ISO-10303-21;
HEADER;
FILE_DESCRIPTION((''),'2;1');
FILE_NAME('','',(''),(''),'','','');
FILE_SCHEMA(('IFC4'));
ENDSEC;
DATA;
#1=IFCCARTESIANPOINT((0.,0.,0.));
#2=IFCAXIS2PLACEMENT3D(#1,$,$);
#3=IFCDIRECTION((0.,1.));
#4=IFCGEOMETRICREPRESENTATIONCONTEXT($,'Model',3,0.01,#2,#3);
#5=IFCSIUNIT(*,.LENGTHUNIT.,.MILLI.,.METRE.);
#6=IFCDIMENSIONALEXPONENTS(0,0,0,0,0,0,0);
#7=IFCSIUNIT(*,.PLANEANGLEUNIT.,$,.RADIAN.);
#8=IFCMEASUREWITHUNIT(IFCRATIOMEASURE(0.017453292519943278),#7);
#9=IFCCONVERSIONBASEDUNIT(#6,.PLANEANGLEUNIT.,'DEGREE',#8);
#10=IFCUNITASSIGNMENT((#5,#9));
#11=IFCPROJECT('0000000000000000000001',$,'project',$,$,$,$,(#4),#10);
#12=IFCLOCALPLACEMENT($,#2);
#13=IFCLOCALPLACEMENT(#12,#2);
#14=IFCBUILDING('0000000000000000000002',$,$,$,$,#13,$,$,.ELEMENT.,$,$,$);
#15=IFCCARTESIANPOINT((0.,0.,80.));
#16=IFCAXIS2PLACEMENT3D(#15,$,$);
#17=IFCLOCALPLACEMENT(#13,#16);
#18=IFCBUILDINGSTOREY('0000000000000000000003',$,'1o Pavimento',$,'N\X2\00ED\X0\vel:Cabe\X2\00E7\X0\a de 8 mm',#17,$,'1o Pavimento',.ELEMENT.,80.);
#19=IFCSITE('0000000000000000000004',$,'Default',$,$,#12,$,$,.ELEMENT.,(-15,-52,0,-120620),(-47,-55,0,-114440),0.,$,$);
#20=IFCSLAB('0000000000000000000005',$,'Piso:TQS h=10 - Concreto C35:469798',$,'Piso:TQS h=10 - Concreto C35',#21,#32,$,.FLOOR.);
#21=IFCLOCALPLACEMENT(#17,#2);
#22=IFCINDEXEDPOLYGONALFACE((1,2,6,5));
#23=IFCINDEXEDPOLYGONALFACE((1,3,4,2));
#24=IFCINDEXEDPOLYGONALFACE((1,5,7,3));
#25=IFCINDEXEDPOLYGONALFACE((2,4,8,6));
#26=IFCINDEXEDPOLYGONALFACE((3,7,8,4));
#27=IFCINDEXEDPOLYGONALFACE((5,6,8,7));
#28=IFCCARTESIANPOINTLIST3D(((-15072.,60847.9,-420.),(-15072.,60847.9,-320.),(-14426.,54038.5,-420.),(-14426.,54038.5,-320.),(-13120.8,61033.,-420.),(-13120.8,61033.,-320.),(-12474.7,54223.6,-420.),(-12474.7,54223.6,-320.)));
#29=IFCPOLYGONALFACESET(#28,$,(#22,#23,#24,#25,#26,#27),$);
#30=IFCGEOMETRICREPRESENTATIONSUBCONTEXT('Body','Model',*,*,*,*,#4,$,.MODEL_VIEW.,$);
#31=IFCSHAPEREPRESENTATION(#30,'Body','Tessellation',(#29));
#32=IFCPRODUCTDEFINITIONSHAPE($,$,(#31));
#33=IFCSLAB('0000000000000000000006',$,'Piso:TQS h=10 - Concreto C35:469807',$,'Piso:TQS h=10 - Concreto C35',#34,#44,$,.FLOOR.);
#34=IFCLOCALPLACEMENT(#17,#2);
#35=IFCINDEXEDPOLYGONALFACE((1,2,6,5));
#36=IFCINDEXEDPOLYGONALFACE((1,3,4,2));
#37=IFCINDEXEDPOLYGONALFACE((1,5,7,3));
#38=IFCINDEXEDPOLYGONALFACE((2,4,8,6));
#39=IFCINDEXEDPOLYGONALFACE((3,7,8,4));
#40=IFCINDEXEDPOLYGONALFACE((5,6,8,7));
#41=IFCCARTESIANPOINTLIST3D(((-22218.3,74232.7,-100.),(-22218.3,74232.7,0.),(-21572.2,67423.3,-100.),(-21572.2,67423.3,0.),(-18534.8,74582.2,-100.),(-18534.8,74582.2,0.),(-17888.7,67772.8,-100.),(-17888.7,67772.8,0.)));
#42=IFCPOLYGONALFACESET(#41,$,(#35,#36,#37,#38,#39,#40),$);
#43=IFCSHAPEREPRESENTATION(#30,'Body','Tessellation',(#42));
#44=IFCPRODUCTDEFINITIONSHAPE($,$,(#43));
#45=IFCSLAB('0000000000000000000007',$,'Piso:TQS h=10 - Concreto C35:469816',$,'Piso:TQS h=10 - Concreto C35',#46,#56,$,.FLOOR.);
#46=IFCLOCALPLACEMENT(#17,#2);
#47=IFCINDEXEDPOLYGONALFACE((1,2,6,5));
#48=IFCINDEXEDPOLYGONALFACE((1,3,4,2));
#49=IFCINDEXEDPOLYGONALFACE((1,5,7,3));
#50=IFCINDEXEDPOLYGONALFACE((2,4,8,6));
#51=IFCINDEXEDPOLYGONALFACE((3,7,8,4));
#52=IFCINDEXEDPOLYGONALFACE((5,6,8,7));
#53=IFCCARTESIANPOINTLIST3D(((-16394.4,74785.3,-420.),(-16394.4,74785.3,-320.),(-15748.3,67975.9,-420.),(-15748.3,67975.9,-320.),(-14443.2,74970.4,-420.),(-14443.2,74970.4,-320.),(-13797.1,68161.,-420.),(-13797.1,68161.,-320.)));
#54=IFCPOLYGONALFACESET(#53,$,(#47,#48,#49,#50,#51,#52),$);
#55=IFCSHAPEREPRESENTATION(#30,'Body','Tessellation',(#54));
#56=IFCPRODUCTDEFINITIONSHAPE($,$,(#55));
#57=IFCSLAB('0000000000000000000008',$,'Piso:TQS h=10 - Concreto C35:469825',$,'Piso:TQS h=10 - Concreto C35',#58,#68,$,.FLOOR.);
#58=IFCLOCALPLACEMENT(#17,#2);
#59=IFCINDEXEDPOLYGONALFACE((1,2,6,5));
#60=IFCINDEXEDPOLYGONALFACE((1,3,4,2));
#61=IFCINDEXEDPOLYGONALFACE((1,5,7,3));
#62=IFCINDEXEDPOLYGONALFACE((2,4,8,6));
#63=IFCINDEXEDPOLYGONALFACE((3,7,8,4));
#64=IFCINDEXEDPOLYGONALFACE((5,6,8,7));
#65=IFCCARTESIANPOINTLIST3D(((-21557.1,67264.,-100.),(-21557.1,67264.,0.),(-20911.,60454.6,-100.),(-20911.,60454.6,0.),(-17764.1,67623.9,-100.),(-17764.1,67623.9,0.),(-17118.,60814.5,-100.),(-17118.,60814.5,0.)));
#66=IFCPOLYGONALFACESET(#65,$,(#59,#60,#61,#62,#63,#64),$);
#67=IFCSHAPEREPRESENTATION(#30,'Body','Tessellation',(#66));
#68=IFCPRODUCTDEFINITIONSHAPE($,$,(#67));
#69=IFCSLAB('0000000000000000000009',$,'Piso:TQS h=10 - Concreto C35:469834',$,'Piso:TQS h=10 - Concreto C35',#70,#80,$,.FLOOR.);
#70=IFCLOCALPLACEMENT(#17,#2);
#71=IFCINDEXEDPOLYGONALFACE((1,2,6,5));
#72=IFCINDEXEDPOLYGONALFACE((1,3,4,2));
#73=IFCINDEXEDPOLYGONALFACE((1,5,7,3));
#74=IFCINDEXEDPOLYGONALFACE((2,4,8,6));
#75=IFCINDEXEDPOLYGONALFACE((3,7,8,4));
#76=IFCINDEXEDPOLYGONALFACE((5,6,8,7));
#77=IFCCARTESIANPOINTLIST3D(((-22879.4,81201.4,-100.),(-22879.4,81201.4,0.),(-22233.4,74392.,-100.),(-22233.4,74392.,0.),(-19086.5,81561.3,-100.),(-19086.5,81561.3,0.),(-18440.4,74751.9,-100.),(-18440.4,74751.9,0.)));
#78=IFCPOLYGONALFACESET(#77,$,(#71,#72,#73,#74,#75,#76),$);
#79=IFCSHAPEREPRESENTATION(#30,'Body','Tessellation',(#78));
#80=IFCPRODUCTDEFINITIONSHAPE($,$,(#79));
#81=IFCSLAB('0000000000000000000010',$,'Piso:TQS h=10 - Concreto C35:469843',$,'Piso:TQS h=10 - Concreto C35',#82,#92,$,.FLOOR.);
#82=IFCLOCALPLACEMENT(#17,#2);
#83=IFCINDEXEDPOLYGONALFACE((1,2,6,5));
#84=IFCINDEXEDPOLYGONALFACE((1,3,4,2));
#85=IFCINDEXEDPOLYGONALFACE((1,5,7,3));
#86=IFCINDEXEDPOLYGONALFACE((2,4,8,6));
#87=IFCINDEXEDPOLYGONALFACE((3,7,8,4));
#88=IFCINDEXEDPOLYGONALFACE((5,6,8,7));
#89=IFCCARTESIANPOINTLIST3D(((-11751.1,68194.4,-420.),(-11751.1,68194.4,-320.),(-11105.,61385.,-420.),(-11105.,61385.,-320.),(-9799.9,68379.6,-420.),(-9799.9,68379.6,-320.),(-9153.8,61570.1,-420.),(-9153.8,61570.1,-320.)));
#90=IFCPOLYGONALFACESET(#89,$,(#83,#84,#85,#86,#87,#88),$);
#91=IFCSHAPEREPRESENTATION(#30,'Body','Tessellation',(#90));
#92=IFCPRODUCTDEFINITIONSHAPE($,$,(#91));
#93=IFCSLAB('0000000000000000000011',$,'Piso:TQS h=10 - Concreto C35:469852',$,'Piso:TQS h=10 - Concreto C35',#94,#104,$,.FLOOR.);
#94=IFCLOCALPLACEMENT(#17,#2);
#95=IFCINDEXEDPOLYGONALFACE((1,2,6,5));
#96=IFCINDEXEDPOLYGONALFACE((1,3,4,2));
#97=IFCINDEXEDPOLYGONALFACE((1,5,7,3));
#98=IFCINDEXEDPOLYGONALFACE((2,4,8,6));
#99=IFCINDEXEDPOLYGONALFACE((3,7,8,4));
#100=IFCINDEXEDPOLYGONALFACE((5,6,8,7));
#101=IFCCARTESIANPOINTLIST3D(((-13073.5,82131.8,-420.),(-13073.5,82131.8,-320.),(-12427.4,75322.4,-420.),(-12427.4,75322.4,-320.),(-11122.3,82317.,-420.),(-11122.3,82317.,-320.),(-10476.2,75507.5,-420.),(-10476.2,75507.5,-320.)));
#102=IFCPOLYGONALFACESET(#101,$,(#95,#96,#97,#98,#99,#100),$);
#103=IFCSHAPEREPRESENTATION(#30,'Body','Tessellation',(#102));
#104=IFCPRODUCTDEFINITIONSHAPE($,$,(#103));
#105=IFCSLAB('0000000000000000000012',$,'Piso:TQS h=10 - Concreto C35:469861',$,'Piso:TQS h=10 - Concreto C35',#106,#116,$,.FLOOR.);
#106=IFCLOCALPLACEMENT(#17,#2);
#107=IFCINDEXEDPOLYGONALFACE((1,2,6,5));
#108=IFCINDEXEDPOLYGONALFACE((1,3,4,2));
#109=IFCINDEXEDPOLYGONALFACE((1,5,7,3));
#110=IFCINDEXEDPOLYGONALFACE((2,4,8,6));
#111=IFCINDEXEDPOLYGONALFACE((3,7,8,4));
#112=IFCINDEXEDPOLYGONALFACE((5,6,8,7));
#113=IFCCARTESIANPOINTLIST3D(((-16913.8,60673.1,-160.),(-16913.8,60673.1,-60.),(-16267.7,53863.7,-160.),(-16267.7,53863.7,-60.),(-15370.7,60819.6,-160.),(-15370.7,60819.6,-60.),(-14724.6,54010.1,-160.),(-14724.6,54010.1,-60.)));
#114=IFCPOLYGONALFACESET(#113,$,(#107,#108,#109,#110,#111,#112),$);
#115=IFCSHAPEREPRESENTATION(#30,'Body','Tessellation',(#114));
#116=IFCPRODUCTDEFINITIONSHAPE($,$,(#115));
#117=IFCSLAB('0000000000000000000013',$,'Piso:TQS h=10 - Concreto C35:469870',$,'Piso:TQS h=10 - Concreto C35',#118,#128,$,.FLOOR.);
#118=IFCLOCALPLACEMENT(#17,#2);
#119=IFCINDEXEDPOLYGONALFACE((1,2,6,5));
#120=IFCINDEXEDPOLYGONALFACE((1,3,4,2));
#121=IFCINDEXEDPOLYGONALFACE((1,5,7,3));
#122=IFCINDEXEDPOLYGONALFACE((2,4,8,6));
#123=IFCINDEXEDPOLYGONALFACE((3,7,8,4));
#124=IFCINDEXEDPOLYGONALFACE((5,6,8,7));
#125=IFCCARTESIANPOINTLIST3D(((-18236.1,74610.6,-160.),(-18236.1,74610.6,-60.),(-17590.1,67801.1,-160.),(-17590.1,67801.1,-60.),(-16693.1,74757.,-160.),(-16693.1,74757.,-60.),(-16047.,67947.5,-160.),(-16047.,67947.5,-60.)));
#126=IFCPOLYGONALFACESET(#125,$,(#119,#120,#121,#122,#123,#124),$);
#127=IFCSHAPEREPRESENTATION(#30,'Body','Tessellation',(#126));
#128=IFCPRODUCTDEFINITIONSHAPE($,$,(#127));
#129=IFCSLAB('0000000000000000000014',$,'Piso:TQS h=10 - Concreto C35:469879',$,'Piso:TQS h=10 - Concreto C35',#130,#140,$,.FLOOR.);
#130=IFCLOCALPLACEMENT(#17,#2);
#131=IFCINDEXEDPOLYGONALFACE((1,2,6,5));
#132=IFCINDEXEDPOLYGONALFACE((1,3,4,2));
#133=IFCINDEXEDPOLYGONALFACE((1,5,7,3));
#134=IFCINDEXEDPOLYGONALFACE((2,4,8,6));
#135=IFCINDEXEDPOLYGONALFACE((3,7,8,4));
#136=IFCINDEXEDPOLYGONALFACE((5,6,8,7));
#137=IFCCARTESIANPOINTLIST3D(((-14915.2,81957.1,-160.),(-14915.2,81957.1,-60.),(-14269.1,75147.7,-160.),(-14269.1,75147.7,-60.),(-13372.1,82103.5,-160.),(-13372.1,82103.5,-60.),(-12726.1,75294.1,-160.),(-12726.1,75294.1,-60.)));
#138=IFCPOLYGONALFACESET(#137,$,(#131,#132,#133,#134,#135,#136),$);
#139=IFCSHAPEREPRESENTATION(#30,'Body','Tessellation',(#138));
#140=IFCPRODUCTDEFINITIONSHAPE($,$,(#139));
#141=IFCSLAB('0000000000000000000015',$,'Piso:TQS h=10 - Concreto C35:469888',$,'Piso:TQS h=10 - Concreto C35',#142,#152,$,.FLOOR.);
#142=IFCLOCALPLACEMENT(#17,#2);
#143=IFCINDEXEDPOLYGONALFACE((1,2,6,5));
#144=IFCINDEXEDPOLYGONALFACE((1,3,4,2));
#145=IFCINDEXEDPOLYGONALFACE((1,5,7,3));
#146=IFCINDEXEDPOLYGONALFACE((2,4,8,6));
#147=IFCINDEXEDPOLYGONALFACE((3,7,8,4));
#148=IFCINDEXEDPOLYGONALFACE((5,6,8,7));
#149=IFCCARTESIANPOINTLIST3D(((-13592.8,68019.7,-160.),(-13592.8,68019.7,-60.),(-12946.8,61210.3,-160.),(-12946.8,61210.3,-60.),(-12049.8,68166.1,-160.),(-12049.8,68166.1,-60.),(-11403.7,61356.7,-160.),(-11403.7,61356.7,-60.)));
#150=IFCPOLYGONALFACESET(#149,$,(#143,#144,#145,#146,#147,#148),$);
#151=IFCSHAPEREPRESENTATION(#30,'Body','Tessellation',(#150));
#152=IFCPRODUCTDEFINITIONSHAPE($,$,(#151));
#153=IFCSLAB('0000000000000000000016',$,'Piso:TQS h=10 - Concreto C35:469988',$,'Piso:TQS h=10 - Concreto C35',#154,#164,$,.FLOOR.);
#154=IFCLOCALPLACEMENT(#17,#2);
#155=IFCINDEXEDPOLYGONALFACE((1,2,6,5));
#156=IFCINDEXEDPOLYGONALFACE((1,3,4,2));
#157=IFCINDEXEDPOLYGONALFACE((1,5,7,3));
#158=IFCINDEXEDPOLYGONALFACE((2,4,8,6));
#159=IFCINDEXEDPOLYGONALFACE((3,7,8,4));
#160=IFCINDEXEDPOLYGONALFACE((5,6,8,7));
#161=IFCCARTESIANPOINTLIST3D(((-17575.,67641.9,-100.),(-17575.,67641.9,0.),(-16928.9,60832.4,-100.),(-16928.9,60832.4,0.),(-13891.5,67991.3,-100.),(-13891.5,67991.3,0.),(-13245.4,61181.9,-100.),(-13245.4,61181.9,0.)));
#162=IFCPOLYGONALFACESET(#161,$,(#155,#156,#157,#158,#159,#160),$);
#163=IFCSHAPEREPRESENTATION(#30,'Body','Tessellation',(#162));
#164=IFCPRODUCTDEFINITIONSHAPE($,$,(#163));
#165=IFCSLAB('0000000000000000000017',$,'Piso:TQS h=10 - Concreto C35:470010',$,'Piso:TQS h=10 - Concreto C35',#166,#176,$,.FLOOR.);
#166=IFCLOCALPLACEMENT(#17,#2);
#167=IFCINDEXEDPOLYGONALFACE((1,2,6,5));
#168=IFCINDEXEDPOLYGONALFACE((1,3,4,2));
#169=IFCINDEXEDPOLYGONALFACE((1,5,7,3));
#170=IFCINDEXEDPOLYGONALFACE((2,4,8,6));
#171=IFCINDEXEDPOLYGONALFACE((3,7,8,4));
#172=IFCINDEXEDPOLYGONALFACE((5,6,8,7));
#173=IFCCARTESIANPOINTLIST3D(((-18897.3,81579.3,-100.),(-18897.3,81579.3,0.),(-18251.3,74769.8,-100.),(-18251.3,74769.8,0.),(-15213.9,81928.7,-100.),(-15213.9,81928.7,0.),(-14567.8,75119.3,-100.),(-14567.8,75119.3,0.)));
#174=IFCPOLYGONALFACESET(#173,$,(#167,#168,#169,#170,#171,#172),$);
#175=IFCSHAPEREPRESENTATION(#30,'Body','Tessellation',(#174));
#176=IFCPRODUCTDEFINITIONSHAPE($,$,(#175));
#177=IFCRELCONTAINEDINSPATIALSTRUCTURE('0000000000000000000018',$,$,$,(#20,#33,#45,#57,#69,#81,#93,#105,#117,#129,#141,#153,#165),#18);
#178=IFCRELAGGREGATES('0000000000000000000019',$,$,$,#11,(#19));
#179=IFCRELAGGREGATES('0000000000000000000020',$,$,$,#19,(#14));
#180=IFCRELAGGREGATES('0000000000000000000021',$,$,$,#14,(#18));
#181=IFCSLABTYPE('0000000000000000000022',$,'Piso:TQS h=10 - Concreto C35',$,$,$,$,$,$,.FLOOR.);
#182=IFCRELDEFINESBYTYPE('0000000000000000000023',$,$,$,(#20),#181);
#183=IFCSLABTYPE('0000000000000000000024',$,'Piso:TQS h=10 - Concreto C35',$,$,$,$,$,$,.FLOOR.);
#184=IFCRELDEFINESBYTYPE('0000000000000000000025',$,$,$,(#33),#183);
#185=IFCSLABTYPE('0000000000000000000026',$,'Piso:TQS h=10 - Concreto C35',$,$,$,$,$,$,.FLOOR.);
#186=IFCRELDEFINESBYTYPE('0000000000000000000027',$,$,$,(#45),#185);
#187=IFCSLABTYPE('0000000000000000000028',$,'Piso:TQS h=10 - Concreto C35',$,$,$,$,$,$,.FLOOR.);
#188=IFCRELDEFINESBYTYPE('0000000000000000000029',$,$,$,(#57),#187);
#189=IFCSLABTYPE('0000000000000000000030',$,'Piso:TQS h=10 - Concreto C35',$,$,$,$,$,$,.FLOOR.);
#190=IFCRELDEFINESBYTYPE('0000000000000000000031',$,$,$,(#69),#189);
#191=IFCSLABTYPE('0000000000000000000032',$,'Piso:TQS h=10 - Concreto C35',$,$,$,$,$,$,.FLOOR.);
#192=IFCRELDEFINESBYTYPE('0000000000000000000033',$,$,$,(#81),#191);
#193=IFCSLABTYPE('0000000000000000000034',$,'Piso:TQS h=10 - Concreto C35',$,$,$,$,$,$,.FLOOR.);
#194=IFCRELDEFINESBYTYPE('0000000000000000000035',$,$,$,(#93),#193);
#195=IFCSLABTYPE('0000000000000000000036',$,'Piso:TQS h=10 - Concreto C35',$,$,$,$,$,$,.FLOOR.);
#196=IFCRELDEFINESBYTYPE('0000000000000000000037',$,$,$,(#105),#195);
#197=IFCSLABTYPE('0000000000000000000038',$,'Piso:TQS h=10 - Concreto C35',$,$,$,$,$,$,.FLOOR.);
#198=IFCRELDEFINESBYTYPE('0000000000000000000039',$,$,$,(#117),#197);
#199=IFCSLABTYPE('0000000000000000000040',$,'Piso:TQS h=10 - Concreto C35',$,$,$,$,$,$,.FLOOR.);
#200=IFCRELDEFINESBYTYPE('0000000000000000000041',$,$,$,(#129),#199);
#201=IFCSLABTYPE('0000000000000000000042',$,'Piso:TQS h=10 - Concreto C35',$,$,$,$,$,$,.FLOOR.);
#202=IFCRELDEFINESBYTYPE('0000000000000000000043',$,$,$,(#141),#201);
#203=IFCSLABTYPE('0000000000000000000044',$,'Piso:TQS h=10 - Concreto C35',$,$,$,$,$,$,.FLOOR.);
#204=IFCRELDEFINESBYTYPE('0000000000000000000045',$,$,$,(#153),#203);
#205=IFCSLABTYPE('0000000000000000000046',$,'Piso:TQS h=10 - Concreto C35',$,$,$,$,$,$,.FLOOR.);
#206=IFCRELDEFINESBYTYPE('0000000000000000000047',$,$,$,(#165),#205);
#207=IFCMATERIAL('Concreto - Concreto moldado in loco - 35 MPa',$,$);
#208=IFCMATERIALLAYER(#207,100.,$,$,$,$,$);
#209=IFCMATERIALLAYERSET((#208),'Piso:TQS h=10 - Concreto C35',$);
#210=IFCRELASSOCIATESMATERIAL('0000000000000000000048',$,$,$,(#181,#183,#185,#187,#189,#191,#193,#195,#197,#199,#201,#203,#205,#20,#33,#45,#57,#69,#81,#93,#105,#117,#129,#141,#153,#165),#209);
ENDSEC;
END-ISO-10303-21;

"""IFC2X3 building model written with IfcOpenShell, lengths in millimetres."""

from ifc_helpers import new_model, entity, si_unit, converted_unit, direction, frame, frame_2d, origin, place, context, subcontext, project, spatial, rectangle, extrude, material, layer, layer_set, layer_usage, type_object, element, save


model = new_model("IFC2X3")

# Units and contexts
model_context = context("Model", 3, precision=0.01, world=origin(), true_north=direction((0.0, 1.0)))
body_context = subcontext(model_context, "Body", "Model", "MODEL_VIEW")
ifc_project = project(units=[si_unit("LENGTHUNIT", "METRE", prefix="MILLI"), converted_unit("PLANEANGLEUNIT", "DEGREE", entity("IfcRatioMeasure", 0.017453292519943278), si_unit("PLANEANGLEUNIT", "RADIAN"), dimensions=[0, 0, 0, 0, 0, 0, 0])], contexts=[model_context])

# Site, building, storey
site_placement = place(None, origin())
site = spatial("IfcSite", under=ifc_project, at=site_placement, Name="Default", CompositionType="ELEMENT", RefLatitude=(-15, -52, 0, -120620), RefLongitude=(-47, -55, 0, -114440), RefElevation=0.0)
building_placement = place(site_placement, origin())
building = spatial("IfcBuilding", under=site, at=building_placement, CompositionType="ELEMENT")
storey_placement = place(building_placement, frame((0.0, 0.0, 80.0)))
storey = spatial("IfcBuildingStorey", under=building, at=storey_placement, Name="1o Pavimento", ObjectType="Nível:Cabeça de 8 mm", LongName="1o Pavimento", CompositionType="ELEMENT", Elevation=80.0)

# Shared definitions
ifc_material = material(Name="Concreto - Concreto moldado in loco - 35 MPa")

# Slabs
ifc_layer = layer(ifc_material, 100.0)
ifc_layer_set = layer_set([ifc_layer], Name="Piso:TQS h=10 - Concreto C35")
ifc_layer_usage_1 = layer_usage(ifc_layer_set, "AXIS3", "POSITIVE", 0.0)
slab_type_1 = type_object("IfcSlabType", Name="Piso:TQS h=10 - Concreto C35", PredefinedType="FLOOR", material=ifc_layer_set)
slab_1_placement = place(storey_placement, origin())
element("IfcSlab", 1, at=slab_1_placement, inside=storey, type_object=slab_type_1, material=ifc_layer_usage_1, Name="Piso:TQS h=10 - Concreto C35:469798", ObjectType="Piso:TQS h=10 - Concreto C35", PredefinedType="FLOOR", context=body_context, shape_type="SweptSolid", body=[
    extrude(rectangle(XDim=6840.0, YDim=1960.0, at=frame_2d((0.0, 0.0), x_axis=(1.0, 0.0))), frame((-13773.4, 57535.8, -320.0), z_axis=(0.0, 0.0, -1.0), x_axis=(0.094456, -0.995529, 0.0)), (0.0, 0.0, 1.0), 100.0),
])
ifc_layer_usage_2 = layer_usage(ifc_layer_set, "AXIS3", "POSITIVE", 0.0)
slab_type_2 = type_object("IfcSlabType", Name="Piso:TQS h=10 - Concreto C35", PredefinedType="FLOOR", material=ifc_layer_set)
slab_2_placement = place(storey_placement, origin())
element("IfcSlab", 2, at=slab_2_placement, inside=storey, type_object=slab_type_2, material=ifc_layer_usage_2, Name="Piso:TQS h=10 - Concreto C35:469807", ObjectType="Piso:TQS h=10 - Concreto C35", PredefinedType="FLOOR", context=body_context, shape_type="SweptSolid", body=[
    extrude(rectangle(XDim=6840.0, YDim=3700.0, at=frame_2d((0.0, 0.0), x_axis=(1.0, 0.0))), frame((-20053.5, 71002.8, 0.0), z_axis=(0.0, 0.0, -1.0), x_axis=(0.094456, -0.995529, 0.0)), (0.0, 0.0, 1.0), 100.0),
])
ifc_layer_usage_3 = layer_usage(ifc_layer_set, "AXIS3", "POSITIVE", 0.0)
slab_type_3 = type_object("IfcSlabType", Name="Piso:TQS h=10 - Concreto C35", PredefinedType="FLOOR", material=ifc_layer_set)
slab_3_placement = place(storey_placement, origin())
element("IfcSlab", 3, at=slab_3_placement, inside=storey, type_object=slab_type_3, material=ifc_layer_usage_3, Name="Piso:TQS h=10 - Concreto C35:469816", ObjectType="Piso:TQS h=10 - Concreto C35", PredefinedType="FLOOR", context=body_context, shape_type="SweptSolid", body=[
    extrude(rectangle(XDim=6840.0, YDim=1960.0, at=frame_2d((0.0, 0.0), x_axis=(1.0, 0.0))), frame((-15095.8, 71473.2, -320.0), z_axis=(0.0, 0.0, -1.0), x_axis=(0.094456, -0.995529, 0.0)), (0.0, 0.0, 1.0), 100.0),
])
ifc_layer_usage_4 = layer_usage(ifc_layer_set, "AXIS3", "POSITIVE", 0.0)
slab_type_4 = type_object("IfcSlabType", Name="Piso:TQS h=10 - Concreto C35", PredefinedType="FLOOR", material=ifc_layer_set)
slab_4_placement = place(storey_placement, origin())
element("IfcSlab", 4, at=slab_4_placement, inside=storey, type_object=slab_type_4, material=ifc_layer_usage_4, Name="Piso:TQS h=10 - Concreto C35:469825", ObjectType="Piso:TQS h=10 - Concreto C35", PredefinedType="FLOOR", context=body_context, shape_type="SweptSolid", body=[
    extrude(rectangle(XDim=6840.0, YDim=3810.0, at=frame_2d((0.0, 0.0), x_axis=(1.0, 0.0))), frame((-19337.5, 64039.3, 0.0), z_axis=(0.0, 0.0, -1.0), x_axis=(0.094456, -0.995529, 0.0)), (0.0, 0.0, 1.0), 100.0),
])
ifc_layer_usage_5 = layer_usage(ifc_layer_set, "AXIS3", "POSITIVE", 0.0)
slab_type_5 = type_object("IfcSlabType", Name="Piso:TQS h=10 - Concreto C35", PredefinedType="FLOOR", material=ifc_layer_set)
slab_5_placement = place(storey_placement, origin())
element("IfcSlab", 5, at=slab_5_placement, inside=storey, type_object=slab_type_5, material=ifc_layer_usage_5, Name="Piso:TQS h=10 - Concreto C35:469834", ObjectType="Piso:TQS h=10 - Concreto C35", PredefinedType="FLOOR", context=body_context, shape_type="SweptSolid", body=[
    extrude(rectangle(XDim=6840.0, YDim=3810.0, at=frame_2d((0.0, 0.0), x_axis=(1.0, 0.0))), frame((-20659.9, 77976.7, 0.0), z_axis=(0.0, 0.0, -1.0), x_axis=(0.094456, -0.995529, 0.0)), (0.0, 0.0, 1.0), 100.0),
])
ifc_layer_usage_6 = layer_usage(ifc_layer_set, "AXIS3", "POSITIVE", 0.0)
slab_type_6 = type_object("IfcSlabType", Name="Piso:TQS h=10 - Concreto C35", PredefinedType="FLOOR", material=ifc_layer_set)
slab_6_placement = place(storey_placement, origin())
element("IfcSlab", 6, at=slab_6_placement, inside=storey, type_object=slab_type_6, material=ifc_layer_usage_6, Name="Piso:TQS h=10 - Concreto C35:469843", ObjectType="Piso:TQS h=10 - Concreto C35", PredefinedType="FLOOR", context=body_context, shape_type="SweptSolid", body=[
    extrude(rectangle(XDim=6840.0, YDim=1960.0, at=frame_2d((0.0, 0.0), x_axis=(1.0, 0.0))), frame((-10452.4, 64882.3, -320.0), z_axis=(0.0, 0.0, -1.0), x_axis=(0.094456, -0.995529, 0.0)), (0.0, 0.0, 1.0), 100.0),
])
ifc_layer_usage_7 = layer_usage(ifc_layer_set, "AXIS3", "POSITIVE", 0.0)
slab_type_7 = type_object("IfcSlabType", Name="Piso:TQS h=10 - Concreto C35", PredefinedType="FLOOR", material=ifc_layer_set)
slab_7_placement = place(storey_placement, origin())
element("IfcSlab", 7, at=slab_7_placement, inside=storey, type_object=slab_type_7, material=ifc_layer_usage_7, Name="Piso:TQS h=10 - Concreto C35:469852", ObjectType="Piso:TQS h=10 - Concreto C35", PredefinedType="FLOOR", context=body_context, shape_type="SweptSolid", body=[
    extrude(rectangle(XDim=6840.0, YDim=1960.0, at=frame_2d((0.0, 0.0), x_axis=(1.0, 0.0))), frame((-11774.8, 78819.7, -320.0), z_axis=(0.0, 0.0, -1.0), x_axis=(0.094456, -0.995529, 0.0)), (0.0, 0.0, 1.0), 100.0),
])
ifc_layer_usage_8 = layer_usage(ifc_layer_set, "AXIS3", "POSITIVE", 0.0)
slab_type_8 = type_object("IfcSlabType", Name="Piso:TQS h=10 - Concreto C35", PredefinedType="FLOOR", material=ifc_layer_set)
slab_8_placement = place(storey_placement, origin())
element("IfcSlab", 8, at=slab_8_placement, inside=storey, type_object=slab_type_8, material=ifc_layer_usage_8, Name="Piso:TQS h=10 - Concreto C35:469861", ObjectType="Piso:TQS h=10 - Concreto C35", PredefinedType="FLOOR", context=body_context, shape_type="SweptSolid", body=[
    extrude(rectangle(XDim=6840.0, YDim=1550.0, at=frame_2d((0.0, 0.0), x_axis=(1.0, 0.0))), frame((-15819.2, 57341.6, -60.0), z_axis=(0.0, 0.0, -1.0), x_axis=(0.094456, -0.995529, 0.0)), (0.0, 0.0, 1.0), 100.0),
])
ifc_layer_usage_9 = layer_usage(ifc_layer_set, "AXIS3", "POSITIVE", 0.0)
slab_type_9 = type_object("IfcSlabType", Name="Piso:TQS h=10 - Concreto C35", PredefinedType="FLOOR", material=ifc_layer_set)
slab_9_placement = place(storey_placement, origin())
element("IfcSlab", 9, at=slab_9_placement, inside=storey, type_object=slab_type_9, material=ifc_layer_usage_9, Name="Piso:TQS h=10 - Concreto C35:469870", ObjectType="Piso:TQS h=10 - Concreto C35", PredefinedType="FLOOR", context=body_context, shape_type="SweptSolid", body=[
    extrude(rectangle(XDim=6840.0, YDim=1550.0, at=frame_2d((0.0, 0.0), x_axis=(1.0, 0.0))), frame((-17141.6, 71279.1, -60.0), z_axis=(0.0, 0.0, -1.0), x_axis=(0.094456, -0.995529, 0.0)), (0.0, 0.0, 1.0), 100.0),
])
ifc_layer_usage_10 = layer_usage(ifc_layer_set, "AXIS3", "POSITIVE", 0.0)
slab_type_10 = type_object("IfcSlabType", Name="Piso:TQS h=10 - Concreto C35", PredefinedType="FLOOR", material=ifc_layer_set)
slab_10_placement = place(storey_placement, origin())
element("IfcSlab", 10, at=slab_10_placement, inside=storey, type_object=slab_type_10, material=ifc_layer_usage_10, Name="Piso:TQS h=10 - Concreto C35:469879", ObjectType="Piso:TQS h=10 - Concreto C35", PredefinedType="FLOOR", context=body_context, shape_type="SweptSolid", body=[
    extrude(rectangle(XDim=6840.0, YDim=1550.0, at=frame_2d((0.0, 0.0), x_axis=(1.0, 0.0))), frame((-13820.6, 78625.6, -60.0), z_axis=(0.0, 0.0, -1.0), x_axis=(0.094456, -0.995529, 0.0)), (0.0, 0.0, 1.0), 100.0),
])
ifc_layer_usage_11 = layer_usage(ifc_layer_set, "AXIS3", "POSITIVE", 0.0)
slab_type_11 = type_object("IfcSlabType", Name="Piso:TQS h=10 - Concreto C35", PredefinedType="FLOOR", material=ifc_layer_set)
slab_11_placement = place(storey_placement, origin())
element("IfcSlab", 11, at=slab_11_placement, inside=storey, type_object=slab_type_11, material=ifc_layer_usage_11, Name="Piso:TQS h=10 - Concreto C35:469888", ObjectType="Piso:TQS h=10 - Concreto C35", PredefinedType="FLOOR", context=body_context, shape_type="SweptSolid", body=[
    extrude(rectangle(XDim=6840.0, YDim=1550.0, at=frame_2d((0.0, 0.0), x_axis=(1.0, 0.0))), frame((-12498.3, 64688.2, -60.0), z_axis=(0.0, 0.0, -1.0), x_axis=(0.094456, -0.995529, 0.0)), (0.0, 0.0, 1.0), 100.0),
])
ifc_layer_usage_12 = layer_usage(ifc_layer_set, "AXIS3", "POSITIVE", 0.0)
slab_type_12 = type_object("IfcSlabType", Name="Piso:TQS h=10 - Concreto C35", PredefinedType="FLOOR", material=ifc_layer_set)
slab_12_placement = place(storey_placement, origin())
element("IfcSlab", 12, at=slab_12_placement, inside=storey, type_object=slab_type_12, material=ifc_layer_usage_12, Name="Piso:TQS h=10 - Concreto C35:469988", ObjectType="Piso:TQS h=10 - Concreto C35", PredefinedType="FLOOR", context=body_context, shape_type="SweptSolid", body=[
    extrude(rectangle(XDim=6840.0, YDim=3700.0, at=frame_2d((0.0, 0.0), x_axis=(1.0, 0.0))), frame((-15410.2, 64411.9, 0.0), z_axis=(0.0, 0.0, -1.0), x_axis=(0.094456, -0.995529, 0.0)), (0.0, 0.0, 1.0), 100.0),
])
ifc_layer_usage_13 = layer_usage(ifc_layer_set, "AXIS3", "POSITIVE", 0.0)
slab_type_13 = type_object("IfcSlabType", Name="Piso:TQS h=10 - Concreto C35", PredefinedType="FLOOR", material=ifc_layer_set)
slab_13_placement = place(storey_placement, origin())
element("IfcSlab", 13, at=slab_13_placement, inside=storey, type_object=slab_type_13, material=ifc_layer_usage_13, Name="Piso:TQS h=10 - Concreto C35:470010", ObjectType="Piso:TQS h=10 - Concreto C35", PredefinedType="FLOOR", context=body_context, shape_type="SweptSolid", body=[
    extrude(rectangle(XDim=6840.0, YDim=3700.0, at=frame_2d((0.0, 0.0), x_axis=(1.0, 0.0))), frame((-16732.6, 78349.3, 0.0), z_axis=(0.0, 0.0, -1.0), x_axis=(0.094456, -0.995529, 0.0)), (0.0, 0.0, 1.0), 100.0),
])

save(model, "model.ifc")
